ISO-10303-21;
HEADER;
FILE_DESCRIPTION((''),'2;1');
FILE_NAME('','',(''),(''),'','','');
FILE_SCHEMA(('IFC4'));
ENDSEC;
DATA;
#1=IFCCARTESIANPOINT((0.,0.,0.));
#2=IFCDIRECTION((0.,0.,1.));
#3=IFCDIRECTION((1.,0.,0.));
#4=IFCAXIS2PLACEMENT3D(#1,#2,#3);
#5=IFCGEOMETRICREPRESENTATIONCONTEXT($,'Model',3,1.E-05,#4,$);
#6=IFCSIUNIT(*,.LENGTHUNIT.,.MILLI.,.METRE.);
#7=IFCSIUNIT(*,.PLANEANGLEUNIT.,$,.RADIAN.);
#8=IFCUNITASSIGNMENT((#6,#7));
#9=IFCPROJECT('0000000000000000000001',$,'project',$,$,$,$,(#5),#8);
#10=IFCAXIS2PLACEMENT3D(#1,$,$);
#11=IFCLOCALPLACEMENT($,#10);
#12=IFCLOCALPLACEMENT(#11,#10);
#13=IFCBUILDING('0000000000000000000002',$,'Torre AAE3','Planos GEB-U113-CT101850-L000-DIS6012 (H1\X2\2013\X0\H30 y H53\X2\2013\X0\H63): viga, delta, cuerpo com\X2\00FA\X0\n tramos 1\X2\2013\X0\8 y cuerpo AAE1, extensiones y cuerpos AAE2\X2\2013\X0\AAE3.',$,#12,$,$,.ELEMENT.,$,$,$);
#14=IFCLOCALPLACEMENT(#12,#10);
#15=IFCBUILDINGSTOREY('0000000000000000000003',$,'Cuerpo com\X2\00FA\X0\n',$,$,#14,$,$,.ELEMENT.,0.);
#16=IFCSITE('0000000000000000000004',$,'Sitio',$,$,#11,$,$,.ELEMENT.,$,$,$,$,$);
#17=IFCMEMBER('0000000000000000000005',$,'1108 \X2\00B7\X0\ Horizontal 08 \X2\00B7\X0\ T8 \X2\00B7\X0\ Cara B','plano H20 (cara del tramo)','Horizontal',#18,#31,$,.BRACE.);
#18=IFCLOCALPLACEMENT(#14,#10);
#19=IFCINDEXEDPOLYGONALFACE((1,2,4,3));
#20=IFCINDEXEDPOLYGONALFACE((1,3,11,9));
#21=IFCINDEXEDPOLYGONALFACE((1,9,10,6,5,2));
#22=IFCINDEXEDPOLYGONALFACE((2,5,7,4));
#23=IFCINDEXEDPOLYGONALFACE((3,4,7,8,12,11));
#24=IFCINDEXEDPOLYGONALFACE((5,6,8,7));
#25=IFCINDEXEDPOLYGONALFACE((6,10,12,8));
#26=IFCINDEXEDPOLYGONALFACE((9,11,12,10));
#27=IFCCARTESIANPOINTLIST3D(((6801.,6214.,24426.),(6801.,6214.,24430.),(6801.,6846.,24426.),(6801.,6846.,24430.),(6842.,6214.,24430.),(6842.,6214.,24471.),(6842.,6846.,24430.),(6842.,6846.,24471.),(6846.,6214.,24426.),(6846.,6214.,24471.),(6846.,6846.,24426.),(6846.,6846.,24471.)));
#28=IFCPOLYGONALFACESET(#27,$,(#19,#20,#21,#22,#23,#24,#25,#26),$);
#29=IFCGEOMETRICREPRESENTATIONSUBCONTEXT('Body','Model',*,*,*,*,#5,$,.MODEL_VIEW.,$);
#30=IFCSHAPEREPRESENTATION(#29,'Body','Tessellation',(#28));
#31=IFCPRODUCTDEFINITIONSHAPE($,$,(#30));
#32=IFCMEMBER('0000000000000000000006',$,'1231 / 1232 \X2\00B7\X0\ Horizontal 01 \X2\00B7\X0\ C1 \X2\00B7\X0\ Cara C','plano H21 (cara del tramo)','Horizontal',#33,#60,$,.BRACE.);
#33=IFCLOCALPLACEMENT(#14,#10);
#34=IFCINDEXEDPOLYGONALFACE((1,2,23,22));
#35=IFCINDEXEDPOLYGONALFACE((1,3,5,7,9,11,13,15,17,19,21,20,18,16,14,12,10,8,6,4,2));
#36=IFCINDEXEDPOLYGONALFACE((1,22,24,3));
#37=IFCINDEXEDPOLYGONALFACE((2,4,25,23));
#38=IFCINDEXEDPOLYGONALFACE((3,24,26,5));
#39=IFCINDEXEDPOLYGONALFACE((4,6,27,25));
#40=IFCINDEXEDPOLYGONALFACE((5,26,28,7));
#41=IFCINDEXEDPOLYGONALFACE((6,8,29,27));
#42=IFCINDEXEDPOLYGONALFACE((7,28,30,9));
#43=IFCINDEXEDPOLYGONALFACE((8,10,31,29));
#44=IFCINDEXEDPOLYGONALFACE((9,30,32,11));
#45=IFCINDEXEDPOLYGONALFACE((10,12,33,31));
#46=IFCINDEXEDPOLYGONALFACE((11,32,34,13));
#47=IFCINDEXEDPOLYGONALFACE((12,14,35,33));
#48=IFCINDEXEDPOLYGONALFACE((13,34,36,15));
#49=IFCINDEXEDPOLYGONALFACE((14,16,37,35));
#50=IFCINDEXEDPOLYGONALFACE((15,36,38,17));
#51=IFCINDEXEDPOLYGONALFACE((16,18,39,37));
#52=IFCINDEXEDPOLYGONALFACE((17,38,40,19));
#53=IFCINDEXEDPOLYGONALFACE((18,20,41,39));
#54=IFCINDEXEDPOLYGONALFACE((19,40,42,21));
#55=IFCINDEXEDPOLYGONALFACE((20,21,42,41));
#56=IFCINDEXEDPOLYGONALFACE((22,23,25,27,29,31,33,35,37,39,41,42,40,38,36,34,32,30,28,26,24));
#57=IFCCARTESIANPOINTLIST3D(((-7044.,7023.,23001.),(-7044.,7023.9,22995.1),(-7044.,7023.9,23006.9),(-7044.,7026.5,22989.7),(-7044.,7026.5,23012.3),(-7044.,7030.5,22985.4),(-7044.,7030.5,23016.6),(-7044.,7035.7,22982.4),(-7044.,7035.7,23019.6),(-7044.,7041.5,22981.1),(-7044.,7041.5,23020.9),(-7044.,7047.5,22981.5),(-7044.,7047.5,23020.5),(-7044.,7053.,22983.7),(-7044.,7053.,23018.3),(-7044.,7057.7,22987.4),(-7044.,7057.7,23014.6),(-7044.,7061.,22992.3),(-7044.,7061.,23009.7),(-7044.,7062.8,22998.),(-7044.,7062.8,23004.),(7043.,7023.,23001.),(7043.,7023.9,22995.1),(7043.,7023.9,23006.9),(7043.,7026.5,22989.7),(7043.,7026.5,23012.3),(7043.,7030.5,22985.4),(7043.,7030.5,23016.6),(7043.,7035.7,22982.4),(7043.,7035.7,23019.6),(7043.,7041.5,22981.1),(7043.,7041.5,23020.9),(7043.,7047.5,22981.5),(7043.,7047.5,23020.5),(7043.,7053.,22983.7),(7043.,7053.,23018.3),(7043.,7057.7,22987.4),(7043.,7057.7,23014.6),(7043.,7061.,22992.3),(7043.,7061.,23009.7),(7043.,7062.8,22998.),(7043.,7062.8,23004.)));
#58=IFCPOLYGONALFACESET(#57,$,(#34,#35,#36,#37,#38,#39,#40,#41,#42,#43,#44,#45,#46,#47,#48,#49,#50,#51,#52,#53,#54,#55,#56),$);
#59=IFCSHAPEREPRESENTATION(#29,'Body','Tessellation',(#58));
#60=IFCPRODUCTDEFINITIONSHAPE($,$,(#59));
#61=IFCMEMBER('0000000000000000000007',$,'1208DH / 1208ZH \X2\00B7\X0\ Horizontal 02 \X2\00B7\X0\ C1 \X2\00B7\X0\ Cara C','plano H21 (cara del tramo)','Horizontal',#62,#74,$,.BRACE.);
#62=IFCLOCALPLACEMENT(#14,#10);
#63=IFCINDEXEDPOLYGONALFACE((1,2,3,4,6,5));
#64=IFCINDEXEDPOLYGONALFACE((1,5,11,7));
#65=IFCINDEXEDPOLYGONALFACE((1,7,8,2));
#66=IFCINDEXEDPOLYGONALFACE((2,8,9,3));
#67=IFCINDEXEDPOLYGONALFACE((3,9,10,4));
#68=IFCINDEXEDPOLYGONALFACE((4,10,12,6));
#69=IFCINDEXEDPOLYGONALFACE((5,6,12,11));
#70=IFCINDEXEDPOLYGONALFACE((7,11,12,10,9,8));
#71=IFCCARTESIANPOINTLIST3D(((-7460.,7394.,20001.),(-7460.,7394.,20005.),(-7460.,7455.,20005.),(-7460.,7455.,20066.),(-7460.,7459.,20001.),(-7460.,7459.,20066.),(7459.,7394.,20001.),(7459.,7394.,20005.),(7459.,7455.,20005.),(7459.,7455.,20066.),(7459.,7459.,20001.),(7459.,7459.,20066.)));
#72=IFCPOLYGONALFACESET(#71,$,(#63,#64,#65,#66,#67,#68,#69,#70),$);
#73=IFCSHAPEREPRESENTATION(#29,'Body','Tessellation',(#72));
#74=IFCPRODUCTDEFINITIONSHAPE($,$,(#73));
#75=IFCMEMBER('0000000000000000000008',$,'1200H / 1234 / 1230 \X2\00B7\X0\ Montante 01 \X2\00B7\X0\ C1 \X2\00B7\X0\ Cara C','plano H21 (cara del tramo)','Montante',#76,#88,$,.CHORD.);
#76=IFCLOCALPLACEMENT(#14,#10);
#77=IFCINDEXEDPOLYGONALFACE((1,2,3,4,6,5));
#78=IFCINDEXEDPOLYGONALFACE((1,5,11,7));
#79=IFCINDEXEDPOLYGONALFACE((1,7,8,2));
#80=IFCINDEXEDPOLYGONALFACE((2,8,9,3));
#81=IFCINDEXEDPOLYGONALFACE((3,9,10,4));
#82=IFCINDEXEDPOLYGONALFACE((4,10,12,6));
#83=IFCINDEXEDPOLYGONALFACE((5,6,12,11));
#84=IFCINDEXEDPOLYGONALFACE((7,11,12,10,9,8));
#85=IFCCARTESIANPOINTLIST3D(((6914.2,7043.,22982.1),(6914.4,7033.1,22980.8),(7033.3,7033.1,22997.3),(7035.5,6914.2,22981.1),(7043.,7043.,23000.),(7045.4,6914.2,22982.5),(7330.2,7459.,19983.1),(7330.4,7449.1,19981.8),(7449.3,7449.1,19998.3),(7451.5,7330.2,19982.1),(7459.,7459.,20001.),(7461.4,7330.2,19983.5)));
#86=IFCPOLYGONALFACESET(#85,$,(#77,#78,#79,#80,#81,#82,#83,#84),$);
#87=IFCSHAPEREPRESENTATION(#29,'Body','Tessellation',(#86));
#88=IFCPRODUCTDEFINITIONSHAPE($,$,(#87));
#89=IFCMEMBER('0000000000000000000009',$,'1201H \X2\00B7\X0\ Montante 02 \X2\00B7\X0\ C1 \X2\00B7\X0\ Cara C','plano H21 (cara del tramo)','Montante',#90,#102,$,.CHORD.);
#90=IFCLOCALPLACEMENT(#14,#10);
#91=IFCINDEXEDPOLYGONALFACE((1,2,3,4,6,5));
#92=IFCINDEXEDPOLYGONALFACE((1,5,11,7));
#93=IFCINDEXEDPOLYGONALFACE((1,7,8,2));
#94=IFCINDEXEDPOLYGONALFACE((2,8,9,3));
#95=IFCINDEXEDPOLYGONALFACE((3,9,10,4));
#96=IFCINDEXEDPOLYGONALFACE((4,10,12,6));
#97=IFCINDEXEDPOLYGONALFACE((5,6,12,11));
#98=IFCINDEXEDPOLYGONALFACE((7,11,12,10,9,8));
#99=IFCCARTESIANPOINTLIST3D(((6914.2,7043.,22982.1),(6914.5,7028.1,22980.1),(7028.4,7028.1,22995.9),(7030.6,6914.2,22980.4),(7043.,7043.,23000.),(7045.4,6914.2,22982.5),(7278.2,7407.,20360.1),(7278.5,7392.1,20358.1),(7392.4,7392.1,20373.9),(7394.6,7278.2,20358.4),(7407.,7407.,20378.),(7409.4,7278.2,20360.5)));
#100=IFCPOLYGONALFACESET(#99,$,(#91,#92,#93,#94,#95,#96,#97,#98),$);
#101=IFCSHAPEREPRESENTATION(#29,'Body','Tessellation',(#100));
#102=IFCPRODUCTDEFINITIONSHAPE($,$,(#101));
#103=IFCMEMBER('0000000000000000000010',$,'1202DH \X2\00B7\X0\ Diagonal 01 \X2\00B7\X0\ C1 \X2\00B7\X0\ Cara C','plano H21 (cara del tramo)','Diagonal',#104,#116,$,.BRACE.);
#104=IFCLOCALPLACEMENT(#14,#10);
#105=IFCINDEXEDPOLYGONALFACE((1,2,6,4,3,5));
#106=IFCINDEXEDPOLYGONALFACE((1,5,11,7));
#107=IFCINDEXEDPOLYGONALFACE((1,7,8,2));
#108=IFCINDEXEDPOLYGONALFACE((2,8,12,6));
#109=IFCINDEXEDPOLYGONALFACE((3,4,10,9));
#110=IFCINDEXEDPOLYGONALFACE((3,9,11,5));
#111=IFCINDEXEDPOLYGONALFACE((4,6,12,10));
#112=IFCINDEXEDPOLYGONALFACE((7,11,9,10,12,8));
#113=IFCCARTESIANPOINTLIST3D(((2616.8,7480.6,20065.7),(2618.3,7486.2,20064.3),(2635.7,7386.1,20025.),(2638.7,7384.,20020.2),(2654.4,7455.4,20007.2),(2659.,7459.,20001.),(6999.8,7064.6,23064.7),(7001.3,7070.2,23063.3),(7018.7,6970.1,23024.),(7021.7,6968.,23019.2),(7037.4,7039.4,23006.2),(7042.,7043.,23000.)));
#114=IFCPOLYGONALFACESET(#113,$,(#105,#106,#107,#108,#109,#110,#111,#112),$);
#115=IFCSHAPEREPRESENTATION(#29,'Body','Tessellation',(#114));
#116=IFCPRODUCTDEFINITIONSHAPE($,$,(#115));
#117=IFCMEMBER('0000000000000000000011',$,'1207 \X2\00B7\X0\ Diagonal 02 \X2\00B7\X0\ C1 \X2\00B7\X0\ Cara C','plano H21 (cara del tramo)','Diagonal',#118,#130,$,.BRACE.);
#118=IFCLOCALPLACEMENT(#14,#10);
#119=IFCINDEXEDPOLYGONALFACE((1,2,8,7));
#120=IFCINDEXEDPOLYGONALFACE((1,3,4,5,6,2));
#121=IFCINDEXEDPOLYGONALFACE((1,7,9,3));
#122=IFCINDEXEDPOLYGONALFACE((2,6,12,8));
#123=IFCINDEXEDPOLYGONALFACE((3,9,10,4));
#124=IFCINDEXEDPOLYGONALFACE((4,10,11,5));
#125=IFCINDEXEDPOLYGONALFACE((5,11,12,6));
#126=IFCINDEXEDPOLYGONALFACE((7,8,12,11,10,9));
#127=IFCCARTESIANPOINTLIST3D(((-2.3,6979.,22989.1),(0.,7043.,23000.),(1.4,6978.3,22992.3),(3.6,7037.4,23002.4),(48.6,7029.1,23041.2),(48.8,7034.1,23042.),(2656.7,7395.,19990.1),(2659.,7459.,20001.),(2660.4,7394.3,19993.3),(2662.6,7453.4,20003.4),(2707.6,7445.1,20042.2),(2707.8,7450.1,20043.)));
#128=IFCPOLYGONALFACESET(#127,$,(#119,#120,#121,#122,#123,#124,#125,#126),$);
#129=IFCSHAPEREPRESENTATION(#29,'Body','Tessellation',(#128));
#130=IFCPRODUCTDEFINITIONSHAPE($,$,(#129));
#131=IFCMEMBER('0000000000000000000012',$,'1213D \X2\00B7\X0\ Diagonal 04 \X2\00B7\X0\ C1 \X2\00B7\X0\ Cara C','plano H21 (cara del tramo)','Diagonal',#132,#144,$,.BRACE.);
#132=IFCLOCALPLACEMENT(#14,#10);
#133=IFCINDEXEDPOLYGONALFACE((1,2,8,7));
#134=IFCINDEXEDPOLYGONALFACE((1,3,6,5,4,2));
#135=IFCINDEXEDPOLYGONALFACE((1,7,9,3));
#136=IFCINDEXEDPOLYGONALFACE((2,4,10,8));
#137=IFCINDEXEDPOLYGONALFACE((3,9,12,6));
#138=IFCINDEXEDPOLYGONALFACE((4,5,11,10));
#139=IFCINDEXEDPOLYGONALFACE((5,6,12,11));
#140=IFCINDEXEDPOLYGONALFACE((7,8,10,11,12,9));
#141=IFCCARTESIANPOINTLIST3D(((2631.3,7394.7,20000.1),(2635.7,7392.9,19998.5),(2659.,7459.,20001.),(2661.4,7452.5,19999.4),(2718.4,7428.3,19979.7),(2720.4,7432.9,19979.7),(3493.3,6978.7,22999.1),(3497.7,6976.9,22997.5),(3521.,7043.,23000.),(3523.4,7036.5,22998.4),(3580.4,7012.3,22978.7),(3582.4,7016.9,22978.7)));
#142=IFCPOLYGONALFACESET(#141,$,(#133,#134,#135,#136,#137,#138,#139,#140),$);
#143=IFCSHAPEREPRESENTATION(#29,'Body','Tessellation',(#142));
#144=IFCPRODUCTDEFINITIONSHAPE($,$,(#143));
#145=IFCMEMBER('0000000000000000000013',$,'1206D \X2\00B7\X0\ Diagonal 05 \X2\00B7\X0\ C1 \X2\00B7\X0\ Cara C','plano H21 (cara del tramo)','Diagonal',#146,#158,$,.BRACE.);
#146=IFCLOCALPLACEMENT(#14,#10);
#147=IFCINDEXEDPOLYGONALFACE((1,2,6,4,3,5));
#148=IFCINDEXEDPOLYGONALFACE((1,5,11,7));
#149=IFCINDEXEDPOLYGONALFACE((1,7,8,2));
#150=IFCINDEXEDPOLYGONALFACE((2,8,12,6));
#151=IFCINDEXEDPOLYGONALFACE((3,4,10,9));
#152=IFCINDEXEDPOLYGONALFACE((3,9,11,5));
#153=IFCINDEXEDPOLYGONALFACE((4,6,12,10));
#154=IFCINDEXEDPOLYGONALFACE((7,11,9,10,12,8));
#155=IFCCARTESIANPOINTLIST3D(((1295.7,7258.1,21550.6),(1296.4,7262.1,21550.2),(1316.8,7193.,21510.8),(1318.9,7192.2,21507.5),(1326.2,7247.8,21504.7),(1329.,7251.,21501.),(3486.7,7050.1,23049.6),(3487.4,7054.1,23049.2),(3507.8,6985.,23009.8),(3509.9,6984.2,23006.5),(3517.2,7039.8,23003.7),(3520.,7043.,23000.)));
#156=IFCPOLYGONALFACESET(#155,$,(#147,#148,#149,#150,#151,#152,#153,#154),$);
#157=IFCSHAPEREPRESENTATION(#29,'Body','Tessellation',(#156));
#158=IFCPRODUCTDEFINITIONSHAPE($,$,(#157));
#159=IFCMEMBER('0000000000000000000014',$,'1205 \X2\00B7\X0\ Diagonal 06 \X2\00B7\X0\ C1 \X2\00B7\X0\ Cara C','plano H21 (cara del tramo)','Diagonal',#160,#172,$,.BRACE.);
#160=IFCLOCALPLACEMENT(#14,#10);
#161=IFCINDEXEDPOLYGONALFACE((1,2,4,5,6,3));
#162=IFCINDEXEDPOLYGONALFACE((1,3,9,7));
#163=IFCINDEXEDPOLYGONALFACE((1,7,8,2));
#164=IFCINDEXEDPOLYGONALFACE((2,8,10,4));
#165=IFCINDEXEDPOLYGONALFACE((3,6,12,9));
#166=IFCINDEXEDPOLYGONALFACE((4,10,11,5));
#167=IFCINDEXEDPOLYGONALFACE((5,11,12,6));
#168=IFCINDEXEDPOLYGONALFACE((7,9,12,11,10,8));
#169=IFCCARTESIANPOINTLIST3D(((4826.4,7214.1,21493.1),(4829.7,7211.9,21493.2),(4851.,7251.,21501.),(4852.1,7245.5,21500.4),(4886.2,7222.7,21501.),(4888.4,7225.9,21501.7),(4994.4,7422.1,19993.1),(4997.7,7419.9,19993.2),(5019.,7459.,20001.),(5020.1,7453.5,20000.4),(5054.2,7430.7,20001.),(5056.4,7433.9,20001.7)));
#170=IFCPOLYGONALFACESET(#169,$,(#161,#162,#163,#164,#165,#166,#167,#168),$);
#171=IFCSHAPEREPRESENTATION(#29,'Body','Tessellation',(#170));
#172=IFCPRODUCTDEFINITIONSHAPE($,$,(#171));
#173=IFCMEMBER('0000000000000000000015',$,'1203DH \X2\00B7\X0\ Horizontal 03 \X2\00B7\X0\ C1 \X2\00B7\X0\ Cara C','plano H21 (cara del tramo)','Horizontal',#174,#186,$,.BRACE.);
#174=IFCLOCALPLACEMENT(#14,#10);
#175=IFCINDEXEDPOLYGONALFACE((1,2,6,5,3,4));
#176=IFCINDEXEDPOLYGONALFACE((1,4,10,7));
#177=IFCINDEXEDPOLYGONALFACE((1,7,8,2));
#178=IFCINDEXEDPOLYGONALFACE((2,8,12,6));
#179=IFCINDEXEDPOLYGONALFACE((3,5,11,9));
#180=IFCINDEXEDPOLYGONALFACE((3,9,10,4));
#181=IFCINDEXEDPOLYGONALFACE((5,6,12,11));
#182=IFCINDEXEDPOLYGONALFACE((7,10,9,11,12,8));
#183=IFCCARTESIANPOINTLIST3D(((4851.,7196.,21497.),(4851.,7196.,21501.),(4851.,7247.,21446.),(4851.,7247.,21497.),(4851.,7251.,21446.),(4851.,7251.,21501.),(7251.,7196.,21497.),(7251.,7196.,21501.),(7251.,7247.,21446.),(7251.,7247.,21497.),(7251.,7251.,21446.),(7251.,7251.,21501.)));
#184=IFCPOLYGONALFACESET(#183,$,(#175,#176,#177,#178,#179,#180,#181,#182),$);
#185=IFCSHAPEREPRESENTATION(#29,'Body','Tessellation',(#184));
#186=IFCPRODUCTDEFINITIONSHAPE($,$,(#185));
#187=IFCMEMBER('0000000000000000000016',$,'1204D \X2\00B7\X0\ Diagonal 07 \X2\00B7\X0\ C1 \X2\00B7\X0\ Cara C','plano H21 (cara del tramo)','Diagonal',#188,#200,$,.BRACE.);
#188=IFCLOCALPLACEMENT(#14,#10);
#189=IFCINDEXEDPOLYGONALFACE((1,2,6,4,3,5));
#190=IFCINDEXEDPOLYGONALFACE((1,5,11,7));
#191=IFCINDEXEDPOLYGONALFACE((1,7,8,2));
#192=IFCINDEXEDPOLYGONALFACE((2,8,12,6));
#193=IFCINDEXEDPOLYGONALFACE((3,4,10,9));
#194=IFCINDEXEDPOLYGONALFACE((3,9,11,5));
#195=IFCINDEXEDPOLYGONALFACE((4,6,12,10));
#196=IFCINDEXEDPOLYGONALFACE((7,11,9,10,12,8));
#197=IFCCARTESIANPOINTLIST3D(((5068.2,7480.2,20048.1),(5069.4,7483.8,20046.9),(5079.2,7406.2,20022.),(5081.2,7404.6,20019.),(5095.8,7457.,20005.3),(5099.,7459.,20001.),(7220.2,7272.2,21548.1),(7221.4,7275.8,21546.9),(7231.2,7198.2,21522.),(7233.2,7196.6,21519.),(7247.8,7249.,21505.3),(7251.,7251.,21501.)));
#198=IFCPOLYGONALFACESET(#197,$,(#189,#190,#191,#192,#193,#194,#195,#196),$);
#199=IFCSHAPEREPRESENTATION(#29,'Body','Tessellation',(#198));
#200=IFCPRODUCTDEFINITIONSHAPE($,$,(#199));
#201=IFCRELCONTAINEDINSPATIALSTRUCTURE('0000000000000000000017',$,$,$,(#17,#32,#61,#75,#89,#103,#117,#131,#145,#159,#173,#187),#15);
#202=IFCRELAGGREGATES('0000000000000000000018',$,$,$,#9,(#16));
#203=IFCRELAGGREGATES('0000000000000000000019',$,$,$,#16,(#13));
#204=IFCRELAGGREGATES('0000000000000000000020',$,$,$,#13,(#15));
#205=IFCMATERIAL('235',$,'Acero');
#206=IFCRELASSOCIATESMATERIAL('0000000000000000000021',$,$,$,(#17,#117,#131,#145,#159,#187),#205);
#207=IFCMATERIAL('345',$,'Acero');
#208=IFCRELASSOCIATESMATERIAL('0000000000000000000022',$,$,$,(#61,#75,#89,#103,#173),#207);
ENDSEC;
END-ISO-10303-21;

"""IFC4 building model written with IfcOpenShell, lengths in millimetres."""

from ifc_helpers import new_model, si_unit, frame, frame_2d, origin, origin_with_axes, place, context, subcontext, project, spatial, circle, l_section, extrude, material, element, save


model = new_model("IFC4")

# Units and contexts
model_context = context("Model", 3, precision=1e-05, world=origin_with_axes())
body_context = subcontext(model_context, "Body", "Model", "MODEL_VIEW")
ifc_project = project(units=[si_unit("LENGTHUNIT", "METRE", prefix="MILLI"), si_unit("PLANEANGLEUNIT", "RADIAN")], contexts=[model_context])

# Site, building, storey
site_placement = place(None, origin())
site = spatial("IfcSite", under=ifc_project, at=site_placement, Name="Sitio", CompositionType="ELEMENT")
building_placement = place(site_placement, origin())
building = spatial("IfcBuilding", under=site, at=building_placement, Name="Torre AAE3", Description="Planos GEB-U113-CT101850-L000-DIS6012 (H1–H30 y H53–H63): viga, delta, cuerpo común tramos 1–8 y cuerpo AAE1, extensiones y cuerpos AAE2–AAE3.", CompositionType="ELEMENT")
storey_placement = place(building_placement, origin())
storey = spatial("IfcBuildingStorey", under=building, at=storey_placement, Name="Cuerpo común", CompositionType="ELEMENT", Elevation=0.0)

# Members
ifc_material_1 = material(Name="345", Category="Acero")
ifc_material_2 = material(Name="235", Category="Acero")
for number, where, z_axis, x_axis, name in (
    (1, (6846.0, 6214.0, 24426.0), (0.0, 1.0, 0.0), (-1.0, 0.0, 0.0), "1108 · Horizontal 08 · T8 · Cara B"),
):
    element("IfcMember", number, at=place(storey_placement, frame(where, z_axis=z_axis, x_axis=x_axis)), inside=storey, material=ifc_material_2, Name=name, Description="plano H20 (cara del tramo)", ObjectType="Horizontal", PredefinedType="BRACE", context=body_context, shape_type="SweptSolid", body=[
        extrude(l_section(Depth=45.0, Width=45.0, Thickness=4.0, at=frame_2d((22.5, 22.5))), None, (0.0, 0.0, 1.0), 632.0),
    ])
member_1_placement = place(storey_placement, frame((7043.0, 7043.0, 23001.0), z_axis=(-1.0, 0.0, 0.0), x_axis=(0.0, -1.0, 0.0)))
element("IfcMember", 2, at=member_1_placement, inside=storey, Name="1231 / 1232 · Horizontal 01 · C1 · Cara C", Description="plano H21 (cara del tramo)", ObjectType="Horizontal", PredefinedType="BRACE", context=body_context, shape_type="SweptSolid", body=[
    extrude(circle(Radius=20.0), None, (0.0, 0.0, 1.0), 14087.0),
])
member_2_placement = place(storey_placement, frame((7459.0, 7459.0, 20001.0), z_axis=(-1.0, 0.0, 0.0), x_axis=(0.0, -1.0, 0.0)))
element("IfcMember", 3, at=member_2_placement, inside=storey, material=ifc_material_1, Name="1208DH / 1208ZH · Horizontal 02 · C1 · Cara C", Description="plano H21 (cara del tramo)", ObjectType="Horizontal", PredefinedType="BRACE", context=body_context, shape_type="SweptSolid", body=[
    extrude(l_section(Depth=65.0, Width=65.0, Thickness=4.0, at=frame_2d((32.5, 32.5))), None, (0.0, 0.0, 1.0), 14919.0),
])
member_3_placement = place(storey_placement, frame((7043.0, 7043.0, 23000.0), z_axis=(0.136119, 0.136119, -0.981297), x_axis=(0.018702, -0.990693, -0.134828)))
element("IfcMember", 4, at=member_3_placement, inside=storey, material=ifc_material_1, Name="1200H / 1234 / 1230 · Montante 01 · C1 · Cara C", Description="plano H21 (cara del tramo)", ObjectType="Montante", PredefinedType="CHORD", context=body_context, shape_type="SweptSolid", body=[
    extrude(l_section(Depth=130.0, Width=130.0, Thickness=10.0, at=frame_2d((65.0, 65.0))), None, (0.0, 0.0, 1.0), 3056.2),
])
member_4_placement = place(storey_placement, frame((7043.0, 7043.0, 23000.0), z_axis=(0.136225, 0.136225, -0.981267), x_axis=(0.018732, -0.990678, -0.134931)))
element("IfcMember", 5, at=member_4_placement, inside=storey, material=ifc_material_1, Name="1201H · Montante 02 · C1 · Cara C", Description="plano H21 (cara del tramo)", ObjectType="Montante", PredefinedType="CHORD", context=body_context, shape_type="SweptSolid", body=[
    extrude(l_section(Depth=130.0, Width=130.0, Thickness=15.0, at=frame_2d((65.0, 65.0))), None, (0.0, 0.0, 1.0), 2672.1),
])
member_5_placement = place(storey_placement, frame((7042.0, 7043.0, 23000.0), z_axis=(-0.822778, 0.078092, -0.562973), x_axis=(-0.253354, -0.937055, 0.240292)))
element("IfcMember", 6, at=member_5_placement, inside=storey, material=ifc_material_1, Name="1202DH · Diagonal 01 · C1 · Cara C", Description="plano H21 (cara del tramo)", ObjectType="Diagonal", PredefinedType="BRACE", context=body_context, shape_type="SweptSolid", body=[
    extrude(l_section(Depth=80.0, Width=80.0, Thickness=6.0, at=frame_2d((40.0, 40.0))), None, (0.0, 0.0, 1.0), 5327.1),
])
member_6_placement = place(storey_placement, frame((2659.0, 7459.0, 20001.0), z_axis=(-0.659874, -0.103237, 0.74425), x_axis=(-0.035691, -0.985091, -0.168289)))
element("IfcMember", 7, at=member_6_placement, inside=storey, material=ifc_material_2, Name="1207 · Diagonal 02 · C1 · Cara C", Description="plano H21 (cara del tramo)", ObjectType="Diagonal", PredefinedType="BRACE", context=body_context, shape_type="SweptSolid", body=[
    extrude(l_section(Depth=65.0, Width=65.0, Thickness=5.0, at=frame_2d((32.5, 32.5))), None, (0.0, 0.0, 1.0), 4029.6),
])
member_7_placement = place(storey_placement, frame((2659.0, 7459.0, 20001.0), z_axis=(0.273822, -0.132146, 0.952659), x_axis=(-0.395969, -0.918164, -0.013548)))
element("IfcMember", 8, at=member_7_placement, inside=storey, material=ifc_material_2, Name="1213D · Diagonal 04 · C1 · Cara C", Description="plano H21 (cara del tramo)", ObjectType="Diagonal", PredefinedType="BRACE", context=body_context, shape_type="SweptSolid", body=[
    extrude(l_section(Depth=70.0, Width=70.0, Thickness=5.0, at=frame_2d((35.0, 35.0))), None, (0.0, 0.0, 1.0), 3148.0),
])
member_8_placement = place(storey_placement, frame((3520.0, 7043.0, 23000.0), z_axis=(-0.822804, 0.078112, -0.562932), x_axis=(-0.167693, -0.979778, 0.109153)))
element("IfcMember", 9, at=member_8_placement, inside=storey, material=ifc_material_2, Name="1206D · Diagonal 05 · C1 · Cara C", Description="plano H21 (cara del tramo)", ObjectType="Diagonal", PredefinedType="BRACE", context=body_context, shape_type="SweptSolid", body=[
    extrude(l_section(Depth=60.0, Width=60.0, Thickness=4.0, at=frame_2d((30.0, 30.0))), None, (0.0, 0.0, 1.0), 2662.8),
])
member_9_placement = place(storey_placement, frame((5019.0, 7459.0, 20001.0), z_axis=(-0.110262, -0.136515, 0.984483), x_axis=(-0.54631, -0.819145, -0.174775)))
element("IfcMember", 10, at=member_9_placement, inside=storey, material=ifc_material_2, Name="1205 · Diagonal 06 · C1 · Cara C", Description="plano H21 (cara del tramo)", ObjectType="Diagonal", PredefinedType="BRACE", context=body_context, shape_type="SweptSolid", body=[
    extrude(l_section(Depth=45.0, Width=45.0, Thickness=4.0, at=frame_2d((22.5, 22.5))), None, (0.0, 0.0, 1.0), 1523.6),
])
member_10_placement = place(storey_placement, frame((4851.0, 7251.0, 21501.0), z_axis=(1.0, 0.0, 0.0), x_axis=(0.0, -1.0, 0.0)))
element("IfcMember", 11, at=member_10_placement, inside=storey, material=ifc_material_1, Name="1203DH · Horizontal 03 · C1 · Cara C", Description="plano H21 (cara del tramo)", ObjectType="Horizontal", PredefinedType="BRACE", context=body_context, shape_type="SweptSolid", body=[
    extrude(l_section(Depth=55.0, Width=55.0, Thickness=4.0, at=frame_2d((27.5, 27.5))), None, (0.0, 0.0, 1.0), 2400.0),
])
member_11_placement = place(storey_placement, frame((7251.0, 7251.0, 21501.0), z_axis=(-0.81781, 0.079045, -0.570035), x_axis=(-0.296517, -0.906797, 0.29966)))
element("IfcMember", 12, at=member_11_placement, inside=storey, material=ifc_material_2, Name="1204D · Diagonal 07 · C1 · Cara C", Description="plano H21 (cara del tramo)", ObjectType="Diagonal", PredefinedType="BRACE", context=body_context, shape_type="SweptSolid", body=[
    extrude(l_section(Depth=60.0, Width=60.0, Thickness=4.0, at=frame_2d((30.0, 30.0))), None, (0.0, 0.0, 1.0), 2631.4),
])

save(model, "model.ifc")
